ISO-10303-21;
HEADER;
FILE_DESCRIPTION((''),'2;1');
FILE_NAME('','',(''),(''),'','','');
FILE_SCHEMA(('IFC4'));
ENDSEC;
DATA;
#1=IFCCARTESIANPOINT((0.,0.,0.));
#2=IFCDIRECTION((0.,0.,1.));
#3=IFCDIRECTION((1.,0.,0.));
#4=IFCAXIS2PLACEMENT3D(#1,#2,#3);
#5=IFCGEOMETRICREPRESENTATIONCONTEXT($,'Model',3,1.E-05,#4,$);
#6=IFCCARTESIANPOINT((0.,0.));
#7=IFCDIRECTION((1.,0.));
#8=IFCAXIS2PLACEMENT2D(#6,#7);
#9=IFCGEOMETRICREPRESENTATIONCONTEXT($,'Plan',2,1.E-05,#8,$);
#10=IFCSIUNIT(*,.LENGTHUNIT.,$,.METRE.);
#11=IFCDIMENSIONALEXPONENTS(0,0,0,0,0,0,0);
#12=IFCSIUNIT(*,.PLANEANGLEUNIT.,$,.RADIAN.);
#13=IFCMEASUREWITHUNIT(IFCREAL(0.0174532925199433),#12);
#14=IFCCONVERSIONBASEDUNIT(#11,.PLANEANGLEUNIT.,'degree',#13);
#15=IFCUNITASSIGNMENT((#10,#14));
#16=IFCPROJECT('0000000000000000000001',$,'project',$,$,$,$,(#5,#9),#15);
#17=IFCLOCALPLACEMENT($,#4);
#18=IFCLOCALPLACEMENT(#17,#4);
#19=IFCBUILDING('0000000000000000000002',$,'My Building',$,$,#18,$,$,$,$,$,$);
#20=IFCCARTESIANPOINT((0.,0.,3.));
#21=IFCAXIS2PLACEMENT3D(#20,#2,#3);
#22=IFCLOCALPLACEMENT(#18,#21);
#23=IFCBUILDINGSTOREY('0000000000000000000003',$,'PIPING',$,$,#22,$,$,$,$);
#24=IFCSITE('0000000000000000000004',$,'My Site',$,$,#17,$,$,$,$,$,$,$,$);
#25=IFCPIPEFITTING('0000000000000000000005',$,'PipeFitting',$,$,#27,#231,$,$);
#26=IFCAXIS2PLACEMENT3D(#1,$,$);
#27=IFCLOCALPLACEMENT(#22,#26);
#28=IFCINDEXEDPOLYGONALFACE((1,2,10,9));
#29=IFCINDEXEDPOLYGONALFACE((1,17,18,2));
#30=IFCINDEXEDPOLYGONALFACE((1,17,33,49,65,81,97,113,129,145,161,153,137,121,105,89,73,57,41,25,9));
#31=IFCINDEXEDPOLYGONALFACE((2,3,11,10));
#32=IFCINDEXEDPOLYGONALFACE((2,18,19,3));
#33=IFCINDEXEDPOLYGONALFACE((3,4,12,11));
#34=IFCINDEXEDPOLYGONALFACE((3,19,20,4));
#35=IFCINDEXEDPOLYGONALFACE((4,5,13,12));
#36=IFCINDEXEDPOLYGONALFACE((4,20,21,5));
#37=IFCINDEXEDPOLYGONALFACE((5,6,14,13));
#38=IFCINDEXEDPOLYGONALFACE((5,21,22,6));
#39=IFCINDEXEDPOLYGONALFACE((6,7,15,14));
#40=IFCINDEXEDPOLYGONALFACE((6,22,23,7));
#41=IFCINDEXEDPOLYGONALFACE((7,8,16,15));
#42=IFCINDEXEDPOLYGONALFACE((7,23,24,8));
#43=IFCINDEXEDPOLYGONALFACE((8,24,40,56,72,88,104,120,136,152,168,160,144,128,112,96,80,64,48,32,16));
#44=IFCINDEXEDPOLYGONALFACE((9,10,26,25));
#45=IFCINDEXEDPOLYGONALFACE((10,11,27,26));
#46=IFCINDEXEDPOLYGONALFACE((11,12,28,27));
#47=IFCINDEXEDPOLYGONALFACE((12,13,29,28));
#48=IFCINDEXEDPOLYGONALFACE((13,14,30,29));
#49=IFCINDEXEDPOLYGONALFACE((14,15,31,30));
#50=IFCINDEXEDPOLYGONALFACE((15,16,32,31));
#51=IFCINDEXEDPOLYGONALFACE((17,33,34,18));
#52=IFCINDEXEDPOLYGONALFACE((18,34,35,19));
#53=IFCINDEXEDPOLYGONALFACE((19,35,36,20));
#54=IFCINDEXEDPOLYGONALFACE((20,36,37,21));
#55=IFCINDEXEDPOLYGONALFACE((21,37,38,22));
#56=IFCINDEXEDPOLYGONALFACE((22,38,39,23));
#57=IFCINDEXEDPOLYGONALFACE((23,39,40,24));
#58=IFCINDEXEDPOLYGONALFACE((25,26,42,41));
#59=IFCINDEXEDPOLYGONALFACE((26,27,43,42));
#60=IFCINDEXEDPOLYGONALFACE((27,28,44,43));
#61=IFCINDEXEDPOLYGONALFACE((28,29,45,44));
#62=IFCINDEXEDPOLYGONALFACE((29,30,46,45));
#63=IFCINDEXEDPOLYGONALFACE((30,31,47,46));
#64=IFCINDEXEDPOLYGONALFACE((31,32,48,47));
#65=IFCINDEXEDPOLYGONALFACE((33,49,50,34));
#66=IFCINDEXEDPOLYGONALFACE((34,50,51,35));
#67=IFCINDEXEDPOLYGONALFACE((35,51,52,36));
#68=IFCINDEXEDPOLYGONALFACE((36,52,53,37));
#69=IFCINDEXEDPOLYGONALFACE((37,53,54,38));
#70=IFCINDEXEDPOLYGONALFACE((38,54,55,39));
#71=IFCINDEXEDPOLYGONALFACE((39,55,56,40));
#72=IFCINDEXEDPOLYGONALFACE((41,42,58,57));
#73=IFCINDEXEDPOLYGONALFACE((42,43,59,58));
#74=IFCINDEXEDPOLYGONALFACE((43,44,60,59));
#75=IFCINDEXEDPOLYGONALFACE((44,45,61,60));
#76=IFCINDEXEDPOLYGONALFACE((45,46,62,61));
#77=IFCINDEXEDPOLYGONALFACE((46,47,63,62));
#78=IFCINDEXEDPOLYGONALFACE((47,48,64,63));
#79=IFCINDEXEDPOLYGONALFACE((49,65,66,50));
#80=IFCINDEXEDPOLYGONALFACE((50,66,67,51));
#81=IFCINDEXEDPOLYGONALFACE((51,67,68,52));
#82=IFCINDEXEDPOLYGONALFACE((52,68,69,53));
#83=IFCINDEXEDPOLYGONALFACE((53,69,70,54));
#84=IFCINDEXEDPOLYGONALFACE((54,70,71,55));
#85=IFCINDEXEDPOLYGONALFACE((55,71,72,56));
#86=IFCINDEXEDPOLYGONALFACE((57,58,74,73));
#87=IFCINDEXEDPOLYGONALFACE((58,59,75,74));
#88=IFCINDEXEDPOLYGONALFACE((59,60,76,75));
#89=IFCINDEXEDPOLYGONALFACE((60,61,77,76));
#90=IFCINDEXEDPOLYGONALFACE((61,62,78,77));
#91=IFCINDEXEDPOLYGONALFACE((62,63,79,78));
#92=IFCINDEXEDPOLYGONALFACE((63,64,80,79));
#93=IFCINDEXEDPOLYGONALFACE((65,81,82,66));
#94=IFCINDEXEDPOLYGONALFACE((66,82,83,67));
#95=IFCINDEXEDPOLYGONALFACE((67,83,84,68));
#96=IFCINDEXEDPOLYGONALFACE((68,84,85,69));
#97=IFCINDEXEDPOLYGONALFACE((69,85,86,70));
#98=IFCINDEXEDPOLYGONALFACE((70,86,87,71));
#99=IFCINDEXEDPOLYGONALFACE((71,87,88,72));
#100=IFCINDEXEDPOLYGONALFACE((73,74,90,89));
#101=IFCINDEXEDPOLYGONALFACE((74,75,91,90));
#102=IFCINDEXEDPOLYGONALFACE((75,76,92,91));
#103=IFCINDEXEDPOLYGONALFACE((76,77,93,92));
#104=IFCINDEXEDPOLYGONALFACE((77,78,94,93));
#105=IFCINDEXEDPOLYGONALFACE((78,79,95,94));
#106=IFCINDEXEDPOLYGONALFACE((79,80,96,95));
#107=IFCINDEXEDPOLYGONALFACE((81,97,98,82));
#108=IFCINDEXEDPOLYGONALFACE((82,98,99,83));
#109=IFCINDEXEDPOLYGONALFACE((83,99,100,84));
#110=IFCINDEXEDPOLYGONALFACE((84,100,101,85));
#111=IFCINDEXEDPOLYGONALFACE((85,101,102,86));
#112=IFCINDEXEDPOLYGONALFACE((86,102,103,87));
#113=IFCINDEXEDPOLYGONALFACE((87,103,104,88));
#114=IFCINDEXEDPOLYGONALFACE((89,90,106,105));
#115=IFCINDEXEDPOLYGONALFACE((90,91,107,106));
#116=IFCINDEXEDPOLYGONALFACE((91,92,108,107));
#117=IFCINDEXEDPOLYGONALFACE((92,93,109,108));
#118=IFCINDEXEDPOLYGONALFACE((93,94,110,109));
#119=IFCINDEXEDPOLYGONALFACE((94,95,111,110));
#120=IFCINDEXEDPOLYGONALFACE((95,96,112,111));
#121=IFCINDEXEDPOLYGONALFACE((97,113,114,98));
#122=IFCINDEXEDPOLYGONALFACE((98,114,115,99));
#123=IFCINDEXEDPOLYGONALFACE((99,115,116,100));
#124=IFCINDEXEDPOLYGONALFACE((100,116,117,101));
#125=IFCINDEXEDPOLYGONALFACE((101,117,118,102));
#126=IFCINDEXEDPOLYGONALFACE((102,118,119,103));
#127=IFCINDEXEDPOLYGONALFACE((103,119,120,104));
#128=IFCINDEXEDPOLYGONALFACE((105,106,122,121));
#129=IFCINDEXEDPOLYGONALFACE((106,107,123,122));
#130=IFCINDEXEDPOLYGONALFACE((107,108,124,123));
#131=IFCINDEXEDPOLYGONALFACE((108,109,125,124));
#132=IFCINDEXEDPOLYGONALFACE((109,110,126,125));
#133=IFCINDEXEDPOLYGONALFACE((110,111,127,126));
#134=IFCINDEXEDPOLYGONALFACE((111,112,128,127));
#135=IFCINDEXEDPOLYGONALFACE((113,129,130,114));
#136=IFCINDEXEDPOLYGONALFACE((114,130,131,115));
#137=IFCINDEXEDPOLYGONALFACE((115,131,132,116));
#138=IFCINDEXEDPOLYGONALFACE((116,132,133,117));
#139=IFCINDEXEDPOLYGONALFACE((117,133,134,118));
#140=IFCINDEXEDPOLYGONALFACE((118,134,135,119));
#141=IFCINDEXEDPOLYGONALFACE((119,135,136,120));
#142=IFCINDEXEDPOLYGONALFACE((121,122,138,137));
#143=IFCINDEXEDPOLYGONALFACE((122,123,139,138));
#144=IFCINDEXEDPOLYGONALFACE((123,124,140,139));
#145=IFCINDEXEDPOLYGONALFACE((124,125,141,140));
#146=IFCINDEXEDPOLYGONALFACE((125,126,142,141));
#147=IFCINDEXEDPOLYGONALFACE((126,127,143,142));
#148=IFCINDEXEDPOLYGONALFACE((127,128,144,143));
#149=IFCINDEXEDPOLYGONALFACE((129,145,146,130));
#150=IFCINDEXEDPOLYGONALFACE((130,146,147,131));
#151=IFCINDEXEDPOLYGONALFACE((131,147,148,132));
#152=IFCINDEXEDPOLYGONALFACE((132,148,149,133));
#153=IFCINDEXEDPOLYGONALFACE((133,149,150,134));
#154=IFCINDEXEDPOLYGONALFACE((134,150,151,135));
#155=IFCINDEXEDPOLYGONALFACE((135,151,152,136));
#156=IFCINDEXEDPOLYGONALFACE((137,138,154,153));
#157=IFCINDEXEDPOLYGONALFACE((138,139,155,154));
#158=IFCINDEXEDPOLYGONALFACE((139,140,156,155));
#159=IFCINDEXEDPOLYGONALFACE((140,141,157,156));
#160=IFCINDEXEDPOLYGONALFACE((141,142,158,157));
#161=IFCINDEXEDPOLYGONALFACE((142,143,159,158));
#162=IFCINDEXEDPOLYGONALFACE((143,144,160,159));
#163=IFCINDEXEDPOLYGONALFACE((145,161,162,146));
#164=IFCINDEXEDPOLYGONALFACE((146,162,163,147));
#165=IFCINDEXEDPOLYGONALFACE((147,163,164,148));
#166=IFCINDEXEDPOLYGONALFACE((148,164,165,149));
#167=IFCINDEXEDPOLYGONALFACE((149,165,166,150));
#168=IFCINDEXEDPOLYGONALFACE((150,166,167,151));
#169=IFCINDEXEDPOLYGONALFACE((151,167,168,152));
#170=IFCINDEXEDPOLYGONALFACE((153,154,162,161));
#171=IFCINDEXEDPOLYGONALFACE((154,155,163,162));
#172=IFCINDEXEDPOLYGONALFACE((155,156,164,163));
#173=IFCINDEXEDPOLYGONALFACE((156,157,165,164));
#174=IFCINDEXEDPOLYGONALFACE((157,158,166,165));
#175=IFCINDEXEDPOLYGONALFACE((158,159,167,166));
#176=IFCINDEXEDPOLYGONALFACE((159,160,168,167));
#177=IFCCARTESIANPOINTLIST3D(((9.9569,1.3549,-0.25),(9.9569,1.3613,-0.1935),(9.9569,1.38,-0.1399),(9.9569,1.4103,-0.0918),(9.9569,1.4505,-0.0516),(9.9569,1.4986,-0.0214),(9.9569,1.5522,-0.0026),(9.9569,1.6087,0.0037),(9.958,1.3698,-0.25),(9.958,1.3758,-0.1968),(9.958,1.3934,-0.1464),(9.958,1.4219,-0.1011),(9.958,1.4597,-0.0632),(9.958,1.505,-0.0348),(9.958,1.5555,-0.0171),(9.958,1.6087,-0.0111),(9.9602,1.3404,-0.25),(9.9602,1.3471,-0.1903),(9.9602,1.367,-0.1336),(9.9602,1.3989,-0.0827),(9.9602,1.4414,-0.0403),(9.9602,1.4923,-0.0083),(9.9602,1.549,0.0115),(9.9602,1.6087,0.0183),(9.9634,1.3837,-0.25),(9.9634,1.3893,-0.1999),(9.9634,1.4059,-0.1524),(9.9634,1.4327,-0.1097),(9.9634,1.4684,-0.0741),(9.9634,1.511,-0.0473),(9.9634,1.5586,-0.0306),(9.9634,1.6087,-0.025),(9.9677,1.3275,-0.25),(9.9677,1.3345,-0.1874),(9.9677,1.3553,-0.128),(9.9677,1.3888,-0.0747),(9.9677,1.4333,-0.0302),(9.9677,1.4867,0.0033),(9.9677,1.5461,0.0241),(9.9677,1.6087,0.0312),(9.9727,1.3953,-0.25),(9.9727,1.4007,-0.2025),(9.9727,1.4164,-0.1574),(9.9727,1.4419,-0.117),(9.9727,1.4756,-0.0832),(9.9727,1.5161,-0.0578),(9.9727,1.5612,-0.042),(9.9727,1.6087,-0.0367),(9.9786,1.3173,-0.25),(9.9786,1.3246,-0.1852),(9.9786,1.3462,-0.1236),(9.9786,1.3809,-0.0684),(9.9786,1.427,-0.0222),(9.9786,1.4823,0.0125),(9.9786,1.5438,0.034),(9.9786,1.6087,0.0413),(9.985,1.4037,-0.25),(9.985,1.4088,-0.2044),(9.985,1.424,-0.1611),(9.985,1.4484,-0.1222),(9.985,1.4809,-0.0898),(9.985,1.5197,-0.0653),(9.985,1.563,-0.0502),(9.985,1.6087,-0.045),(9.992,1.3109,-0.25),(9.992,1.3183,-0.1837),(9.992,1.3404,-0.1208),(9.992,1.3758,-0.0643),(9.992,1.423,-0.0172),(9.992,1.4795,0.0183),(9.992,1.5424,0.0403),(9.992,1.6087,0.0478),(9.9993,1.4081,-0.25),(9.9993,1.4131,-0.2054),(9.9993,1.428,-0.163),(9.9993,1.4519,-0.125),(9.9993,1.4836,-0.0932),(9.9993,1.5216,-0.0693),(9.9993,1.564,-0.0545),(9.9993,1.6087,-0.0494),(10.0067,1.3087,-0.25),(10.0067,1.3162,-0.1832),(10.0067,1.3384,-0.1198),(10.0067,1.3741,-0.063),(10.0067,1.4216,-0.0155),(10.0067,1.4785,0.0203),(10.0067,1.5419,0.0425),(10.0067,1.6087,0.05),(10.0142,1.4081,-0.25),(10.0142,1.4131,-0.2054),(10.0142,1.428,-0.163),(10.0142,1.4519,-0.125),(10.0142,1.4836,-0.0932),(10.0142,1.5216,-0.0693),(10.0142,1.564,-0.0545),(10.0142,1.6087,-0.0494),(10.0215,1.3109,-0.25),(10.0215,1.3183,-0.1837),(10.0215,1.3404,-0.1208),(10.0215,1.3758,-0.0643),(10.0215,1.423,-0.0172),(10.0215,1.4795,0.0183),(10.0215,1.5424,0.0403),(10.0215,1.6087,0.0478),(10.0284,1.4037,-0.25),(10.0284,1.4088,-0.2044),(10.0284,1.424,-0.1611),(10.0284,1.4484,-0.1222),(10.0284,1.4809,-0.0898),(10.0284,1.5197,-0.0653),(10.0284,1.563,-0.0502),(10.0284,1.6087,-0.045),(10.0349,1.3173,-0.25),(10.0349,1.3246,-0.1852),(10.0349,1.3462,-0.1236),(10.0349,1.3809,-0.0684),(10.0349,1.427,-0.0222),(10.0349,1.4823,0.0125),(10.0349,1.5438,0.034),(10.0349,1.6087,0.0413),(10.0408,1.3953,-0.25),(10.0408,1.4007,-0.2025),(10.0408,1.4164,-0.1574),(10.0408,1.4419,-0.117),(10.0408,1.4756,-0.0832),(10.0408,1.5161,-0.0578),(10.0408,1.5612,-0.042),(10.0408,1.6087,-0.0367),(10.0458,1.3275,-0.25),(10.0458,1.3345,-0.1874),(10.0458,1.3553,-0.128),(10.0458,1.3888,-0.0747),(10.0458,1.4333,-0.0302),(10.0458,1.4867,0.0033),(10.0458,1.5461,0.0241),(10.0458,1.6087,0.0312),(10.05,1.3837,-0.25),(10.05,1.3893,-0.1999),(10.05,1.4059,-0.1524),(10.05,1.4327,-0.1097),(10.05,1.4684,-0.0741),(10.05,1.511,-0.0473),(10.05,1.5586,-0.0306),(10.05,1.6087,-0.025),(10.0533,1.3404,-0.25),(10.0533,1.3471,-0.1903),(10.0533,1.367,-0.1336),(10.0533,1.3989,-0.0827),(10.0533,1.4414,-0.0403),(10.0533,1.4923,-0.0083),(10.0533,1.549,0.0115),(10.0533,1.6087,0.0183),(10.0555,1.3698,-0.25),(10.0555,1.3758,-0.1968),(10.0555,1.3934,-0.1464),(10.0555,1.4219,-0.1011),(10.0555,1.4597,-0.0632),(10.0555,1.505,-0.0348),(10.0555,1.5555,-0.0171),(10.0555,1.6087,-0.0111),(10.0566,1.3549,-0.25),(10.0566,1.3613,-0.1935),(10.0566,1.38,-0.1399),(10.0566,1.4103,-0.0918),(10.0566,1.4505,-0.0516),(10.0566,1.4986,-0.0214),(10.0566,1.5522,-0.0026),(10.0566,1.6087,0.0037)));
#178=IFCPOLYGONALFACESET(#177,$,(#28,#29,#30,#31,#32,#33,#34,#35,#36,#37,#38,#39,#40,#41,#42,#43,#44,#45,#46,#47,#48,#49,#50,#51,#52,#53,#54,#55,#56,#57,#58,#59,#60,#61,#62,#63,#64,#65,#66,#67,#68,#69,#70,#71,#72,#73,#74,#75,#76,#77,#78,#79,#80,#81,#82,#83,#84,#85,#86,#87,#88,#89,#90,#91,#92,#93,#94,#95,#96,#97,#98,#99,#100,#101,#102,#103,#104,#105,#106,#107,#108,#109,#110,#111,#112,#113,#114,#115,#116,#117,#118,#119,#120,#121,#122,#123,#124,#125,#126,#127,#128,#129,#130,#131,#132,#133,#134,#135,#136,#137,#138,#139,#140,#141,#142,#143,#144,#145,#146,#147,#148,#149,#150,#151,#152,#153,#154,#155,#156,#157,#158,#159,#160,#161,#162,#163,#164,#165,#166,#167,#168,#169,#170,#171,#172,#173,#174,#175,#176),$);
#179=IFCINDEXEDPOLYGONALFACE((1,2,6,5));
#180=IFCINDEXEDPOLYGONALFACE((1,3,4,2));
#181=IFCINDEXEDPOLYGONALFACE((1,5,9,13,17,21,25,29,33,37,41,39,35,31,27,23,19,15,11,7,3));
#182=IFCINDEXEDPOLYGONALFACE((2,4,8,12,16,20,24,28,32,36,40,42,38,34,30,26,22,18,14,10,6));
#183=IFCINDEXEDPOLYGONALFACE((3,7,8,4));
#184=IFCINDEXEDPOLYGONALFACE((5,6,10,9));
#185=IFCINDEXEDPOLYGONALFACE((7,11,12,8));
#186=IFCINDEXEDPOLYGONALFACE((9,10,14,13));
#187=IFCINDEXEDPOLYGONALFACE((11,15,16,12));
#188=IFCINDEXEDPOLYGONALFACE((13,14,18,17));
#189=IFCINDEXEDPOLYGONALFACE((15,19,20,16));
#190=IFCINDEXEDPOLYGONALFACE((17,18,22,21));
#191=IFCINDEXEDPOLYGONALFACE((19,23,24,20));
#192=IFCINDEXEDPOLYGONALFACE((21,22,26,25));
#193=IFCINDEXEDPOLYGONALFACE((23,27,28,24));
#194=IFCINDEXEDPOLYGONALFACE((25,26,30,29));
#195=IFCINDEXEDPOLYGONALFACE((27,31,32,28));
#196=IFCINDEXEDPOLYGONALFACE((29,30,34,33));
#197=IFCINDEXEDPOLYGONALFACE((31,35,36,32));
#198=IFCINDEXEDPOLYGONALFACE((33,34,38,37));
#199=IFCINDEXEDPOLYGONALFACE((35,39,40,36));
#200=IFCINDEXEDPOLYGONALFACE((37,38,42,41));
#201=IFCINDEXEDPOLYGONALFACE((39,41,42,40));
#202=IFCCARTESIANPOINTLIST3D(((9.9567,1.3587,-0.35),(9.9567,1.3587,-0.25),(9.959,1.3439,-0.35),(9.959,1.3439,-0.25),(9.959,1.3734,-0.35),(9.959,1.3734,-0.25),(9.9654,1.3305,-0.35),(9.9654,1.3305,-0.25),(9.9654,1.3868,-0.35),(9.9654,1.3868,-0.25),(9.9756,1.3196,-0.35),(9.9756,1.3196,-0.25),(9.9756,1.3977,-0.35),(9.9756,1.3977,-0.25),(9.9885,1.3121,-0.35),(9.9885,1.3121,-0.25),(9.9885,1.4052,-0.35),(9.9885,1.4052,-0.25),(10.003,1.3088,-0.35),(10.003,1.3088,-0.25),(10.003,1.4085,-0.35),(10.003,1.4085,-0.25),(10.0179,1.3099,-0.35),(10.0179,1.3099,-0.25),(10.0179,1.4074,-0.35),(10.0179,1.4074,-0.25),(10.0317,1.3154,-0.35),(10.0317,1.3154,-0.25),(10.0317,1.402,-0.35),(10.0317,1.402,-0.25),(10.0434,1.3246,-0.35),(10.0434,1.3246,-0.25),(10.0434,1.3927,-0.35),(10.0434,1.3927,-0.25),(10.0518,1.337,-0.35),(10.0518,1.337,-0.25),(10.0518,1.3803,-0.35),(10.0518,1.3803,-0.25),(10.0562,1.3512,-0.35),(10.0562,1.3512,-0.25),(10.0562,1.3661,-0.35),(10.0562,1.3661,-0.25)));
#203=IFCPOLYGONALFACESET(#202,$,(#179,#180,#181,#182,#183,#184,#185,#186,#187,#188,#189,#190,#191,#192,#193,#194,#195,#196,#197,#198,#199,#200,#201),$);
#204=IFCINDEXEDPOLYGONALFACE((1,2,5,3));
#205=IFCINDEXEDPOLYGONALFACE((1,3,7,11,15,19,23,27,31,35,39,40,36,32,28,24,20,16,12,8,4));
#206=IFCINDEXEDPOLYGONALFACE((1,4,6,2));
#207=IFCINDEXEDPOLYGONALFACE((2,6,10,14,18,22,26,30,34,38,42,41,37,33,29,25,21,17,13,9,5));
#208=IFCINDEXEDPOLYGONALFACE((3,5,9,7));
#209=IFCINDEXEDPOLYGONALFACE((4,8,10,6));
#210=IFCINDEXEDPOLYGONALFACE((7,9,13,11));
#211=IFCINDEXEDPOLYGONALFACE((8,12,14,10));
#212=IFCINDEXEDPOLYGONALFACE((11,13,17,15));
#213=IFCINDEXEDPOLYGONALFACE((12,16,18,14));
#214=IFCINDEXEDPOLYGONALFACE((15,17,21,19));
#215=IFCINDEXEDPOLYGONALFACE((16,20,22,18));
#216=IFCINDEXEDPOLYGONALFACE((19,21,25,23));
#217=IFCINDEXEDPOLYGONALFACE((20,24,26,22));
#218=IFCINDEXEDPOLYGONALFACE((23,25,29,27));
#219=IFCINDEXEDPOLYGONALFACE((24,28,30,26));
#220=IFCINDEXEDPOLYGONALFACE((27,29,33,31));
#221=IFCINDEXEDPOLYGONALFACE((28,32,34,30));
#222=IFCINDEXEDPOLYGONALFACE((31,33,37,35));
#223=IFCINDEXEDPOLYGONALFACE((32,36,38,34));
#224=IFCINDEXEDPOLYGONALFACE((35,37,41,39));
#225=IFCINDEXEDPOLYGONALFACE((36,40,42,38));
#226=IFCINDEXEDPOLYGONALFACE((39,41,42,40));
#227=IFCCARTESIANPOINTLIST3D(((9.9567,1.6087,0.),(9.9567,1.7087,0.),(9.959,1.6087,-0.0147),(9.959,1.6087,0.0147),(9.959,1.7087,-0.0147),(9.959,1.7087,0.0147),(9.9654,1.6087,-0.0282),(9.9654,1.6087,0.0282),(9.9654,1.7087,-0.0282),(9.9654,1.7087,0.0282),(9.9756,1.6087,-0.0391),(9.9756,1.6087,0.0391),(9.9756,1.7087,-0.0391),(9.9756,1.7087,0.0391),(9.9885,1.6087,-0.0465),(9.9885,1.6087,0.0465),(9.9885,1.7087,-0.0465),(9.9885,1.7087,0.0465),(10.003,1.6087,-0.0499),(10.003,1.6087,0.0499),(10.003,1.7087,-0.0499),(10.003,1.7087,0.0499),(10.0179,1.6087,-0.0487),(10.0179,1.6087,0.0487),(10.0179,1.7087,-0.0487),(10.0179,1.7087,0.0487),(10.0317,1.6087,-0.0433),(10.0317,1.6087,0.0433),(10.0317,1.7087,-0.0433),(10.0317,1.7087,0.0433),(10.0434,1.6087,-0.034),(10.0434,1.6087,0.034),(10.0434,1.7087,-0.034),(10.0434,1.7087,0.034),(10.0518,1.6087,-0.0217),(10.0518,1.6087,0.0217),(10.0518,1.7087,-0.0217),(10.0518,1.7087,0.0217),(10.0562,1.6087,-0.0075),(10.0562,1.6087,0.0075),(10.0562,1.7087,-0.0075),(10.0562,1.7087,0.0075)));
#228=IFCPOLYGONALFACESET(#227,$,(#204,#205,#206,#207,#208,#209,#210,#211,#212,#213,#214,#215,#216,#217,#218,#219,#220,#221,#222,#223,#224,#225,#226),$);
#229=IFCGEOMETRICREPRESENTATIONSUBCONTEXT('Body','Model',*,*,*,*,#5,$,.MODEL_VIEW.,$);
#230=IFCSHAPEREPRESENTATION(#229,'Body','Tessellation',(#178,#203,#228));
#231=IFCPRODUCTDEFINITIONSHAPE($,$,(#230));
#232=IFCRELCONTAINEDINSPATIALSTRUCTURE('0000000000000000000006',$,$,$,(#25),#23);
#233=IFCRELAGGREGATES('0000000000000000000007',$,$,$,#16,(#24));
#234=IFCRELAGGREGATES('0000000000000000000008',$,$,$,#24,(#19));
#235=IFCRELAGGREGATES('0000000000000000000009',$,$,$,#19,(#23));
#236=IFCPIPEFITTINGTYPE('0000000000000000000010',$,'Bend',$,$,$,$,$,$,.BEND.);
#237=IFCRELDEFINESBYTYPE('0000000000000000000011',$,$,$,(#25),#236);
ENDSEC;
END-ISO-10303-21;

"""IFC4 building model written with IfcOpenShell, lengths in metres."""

from ifc_helpers import new_model, entity, si_unit, converted_unit, frame, origin_with_axes, origin_2d_with_axis, place, context, subcontext, project, spatial, circle, extrude, source, transform, mapped, type_object, type_shapes, element, save


model = new_model("IFC4")

# Units and contexts
model_context = context("Model", 3, precision=1e-05, world=origin_with_axes())
plan_context = context("Plan", 2, precision=1e-05, world=origin_2d_with_axis())
body_context = subcontext(model_context, "Body", "Model", "MODEL_VIEW")
ifc_project = project(units=[si_unit("LENGTHUNIT", "METRE"), converted_unit("PLANEANGLEUNIT", "degree", entity("IfcReal", 0.0174532925199433), si_unit("PLANEANGLEUNIT", "RADIAN"), dimensions=[0, 0, 0, 0, 0, 0, 0])], contexts=[model_context, plan_context])

# Site, building, storey
site_placement = place(None, origin_with_axes())
site = spatial("IfcSite", under=ifc_project, at=site_placement, Name="My Site")
building_placement = place(site_placement, origin_with_axes())
building = spatial("IfcBuilding", under=site, at=building_placement, Name="My Building")
storey_placement = place(building_placement, frame((0.0, 0.0, 3.0), z_axis=(0.0, 0.0, 1.0), x_axis=(1.0, 0.0, 0.0)))
storey = spatial("IfcBuildingStorey", under=building, at=storey_placement, Name="PIPING")

# Pipe fitting
pipe_fitting_type_1 = type_object("IfcPipeFittingType", Name="Bend", PredefinedType="BEND")
shared_shape = source(origin_with_axes(), body_context, "Body", "SolidModel", [
    entity("IfcSweptDiskSolid", entity("IfcIndexedPolyCurve", entity("IfcCartesianPointList3D", [[0.0, 0.0, -0.1], [0.0, 0.0732, -0.2768], [0.0, 0.25, -0.35]]), [entity("IfcArcIndex", [1, 2, 3])]), 0.05),
    extrude(circle(Radius=0.05), origin_with_axes(), (0.0, 0.0, -1.0), 0.1),
    extrude(circle(Radius=0.05), frame((0.0, 0.25, -0.35), z_axis=(0.0, 1.0, 0.0), x_axis=(1.0, 0.0, 0.0)), (0.0, 0.0, 1.0), 0.1),
])
type_shapes(pipe_fitting_type_1, [shared_shape])
for number, where, z_axis, x_axis, name in (
    (1, (10.0067, 1.3587, -0.35), (0.0, 0.0, -1.0), (-1.0, 0.0, 0.0), "PipeFitting"),
):
    element("IfcPipeFitting", number, at=place(storey_placement, frame(where, z_axis=z_axis, x_axis=x_axis)), inside=storey, type_object=pipe_fitting_type_1, Name=name, context=body_context, shape_type="MappedRepresentation", body=[
        mapped(shared_shape, transform((0.0, 0.0, 0.0), x_axis=(1.0, 0.0, 0.0), y_axis=(0.0, 1.0, 0.0), z_axis=(0.0, 0.0, 1.0), scale=1.0)),
    ])

save(model, "model.ifc")
